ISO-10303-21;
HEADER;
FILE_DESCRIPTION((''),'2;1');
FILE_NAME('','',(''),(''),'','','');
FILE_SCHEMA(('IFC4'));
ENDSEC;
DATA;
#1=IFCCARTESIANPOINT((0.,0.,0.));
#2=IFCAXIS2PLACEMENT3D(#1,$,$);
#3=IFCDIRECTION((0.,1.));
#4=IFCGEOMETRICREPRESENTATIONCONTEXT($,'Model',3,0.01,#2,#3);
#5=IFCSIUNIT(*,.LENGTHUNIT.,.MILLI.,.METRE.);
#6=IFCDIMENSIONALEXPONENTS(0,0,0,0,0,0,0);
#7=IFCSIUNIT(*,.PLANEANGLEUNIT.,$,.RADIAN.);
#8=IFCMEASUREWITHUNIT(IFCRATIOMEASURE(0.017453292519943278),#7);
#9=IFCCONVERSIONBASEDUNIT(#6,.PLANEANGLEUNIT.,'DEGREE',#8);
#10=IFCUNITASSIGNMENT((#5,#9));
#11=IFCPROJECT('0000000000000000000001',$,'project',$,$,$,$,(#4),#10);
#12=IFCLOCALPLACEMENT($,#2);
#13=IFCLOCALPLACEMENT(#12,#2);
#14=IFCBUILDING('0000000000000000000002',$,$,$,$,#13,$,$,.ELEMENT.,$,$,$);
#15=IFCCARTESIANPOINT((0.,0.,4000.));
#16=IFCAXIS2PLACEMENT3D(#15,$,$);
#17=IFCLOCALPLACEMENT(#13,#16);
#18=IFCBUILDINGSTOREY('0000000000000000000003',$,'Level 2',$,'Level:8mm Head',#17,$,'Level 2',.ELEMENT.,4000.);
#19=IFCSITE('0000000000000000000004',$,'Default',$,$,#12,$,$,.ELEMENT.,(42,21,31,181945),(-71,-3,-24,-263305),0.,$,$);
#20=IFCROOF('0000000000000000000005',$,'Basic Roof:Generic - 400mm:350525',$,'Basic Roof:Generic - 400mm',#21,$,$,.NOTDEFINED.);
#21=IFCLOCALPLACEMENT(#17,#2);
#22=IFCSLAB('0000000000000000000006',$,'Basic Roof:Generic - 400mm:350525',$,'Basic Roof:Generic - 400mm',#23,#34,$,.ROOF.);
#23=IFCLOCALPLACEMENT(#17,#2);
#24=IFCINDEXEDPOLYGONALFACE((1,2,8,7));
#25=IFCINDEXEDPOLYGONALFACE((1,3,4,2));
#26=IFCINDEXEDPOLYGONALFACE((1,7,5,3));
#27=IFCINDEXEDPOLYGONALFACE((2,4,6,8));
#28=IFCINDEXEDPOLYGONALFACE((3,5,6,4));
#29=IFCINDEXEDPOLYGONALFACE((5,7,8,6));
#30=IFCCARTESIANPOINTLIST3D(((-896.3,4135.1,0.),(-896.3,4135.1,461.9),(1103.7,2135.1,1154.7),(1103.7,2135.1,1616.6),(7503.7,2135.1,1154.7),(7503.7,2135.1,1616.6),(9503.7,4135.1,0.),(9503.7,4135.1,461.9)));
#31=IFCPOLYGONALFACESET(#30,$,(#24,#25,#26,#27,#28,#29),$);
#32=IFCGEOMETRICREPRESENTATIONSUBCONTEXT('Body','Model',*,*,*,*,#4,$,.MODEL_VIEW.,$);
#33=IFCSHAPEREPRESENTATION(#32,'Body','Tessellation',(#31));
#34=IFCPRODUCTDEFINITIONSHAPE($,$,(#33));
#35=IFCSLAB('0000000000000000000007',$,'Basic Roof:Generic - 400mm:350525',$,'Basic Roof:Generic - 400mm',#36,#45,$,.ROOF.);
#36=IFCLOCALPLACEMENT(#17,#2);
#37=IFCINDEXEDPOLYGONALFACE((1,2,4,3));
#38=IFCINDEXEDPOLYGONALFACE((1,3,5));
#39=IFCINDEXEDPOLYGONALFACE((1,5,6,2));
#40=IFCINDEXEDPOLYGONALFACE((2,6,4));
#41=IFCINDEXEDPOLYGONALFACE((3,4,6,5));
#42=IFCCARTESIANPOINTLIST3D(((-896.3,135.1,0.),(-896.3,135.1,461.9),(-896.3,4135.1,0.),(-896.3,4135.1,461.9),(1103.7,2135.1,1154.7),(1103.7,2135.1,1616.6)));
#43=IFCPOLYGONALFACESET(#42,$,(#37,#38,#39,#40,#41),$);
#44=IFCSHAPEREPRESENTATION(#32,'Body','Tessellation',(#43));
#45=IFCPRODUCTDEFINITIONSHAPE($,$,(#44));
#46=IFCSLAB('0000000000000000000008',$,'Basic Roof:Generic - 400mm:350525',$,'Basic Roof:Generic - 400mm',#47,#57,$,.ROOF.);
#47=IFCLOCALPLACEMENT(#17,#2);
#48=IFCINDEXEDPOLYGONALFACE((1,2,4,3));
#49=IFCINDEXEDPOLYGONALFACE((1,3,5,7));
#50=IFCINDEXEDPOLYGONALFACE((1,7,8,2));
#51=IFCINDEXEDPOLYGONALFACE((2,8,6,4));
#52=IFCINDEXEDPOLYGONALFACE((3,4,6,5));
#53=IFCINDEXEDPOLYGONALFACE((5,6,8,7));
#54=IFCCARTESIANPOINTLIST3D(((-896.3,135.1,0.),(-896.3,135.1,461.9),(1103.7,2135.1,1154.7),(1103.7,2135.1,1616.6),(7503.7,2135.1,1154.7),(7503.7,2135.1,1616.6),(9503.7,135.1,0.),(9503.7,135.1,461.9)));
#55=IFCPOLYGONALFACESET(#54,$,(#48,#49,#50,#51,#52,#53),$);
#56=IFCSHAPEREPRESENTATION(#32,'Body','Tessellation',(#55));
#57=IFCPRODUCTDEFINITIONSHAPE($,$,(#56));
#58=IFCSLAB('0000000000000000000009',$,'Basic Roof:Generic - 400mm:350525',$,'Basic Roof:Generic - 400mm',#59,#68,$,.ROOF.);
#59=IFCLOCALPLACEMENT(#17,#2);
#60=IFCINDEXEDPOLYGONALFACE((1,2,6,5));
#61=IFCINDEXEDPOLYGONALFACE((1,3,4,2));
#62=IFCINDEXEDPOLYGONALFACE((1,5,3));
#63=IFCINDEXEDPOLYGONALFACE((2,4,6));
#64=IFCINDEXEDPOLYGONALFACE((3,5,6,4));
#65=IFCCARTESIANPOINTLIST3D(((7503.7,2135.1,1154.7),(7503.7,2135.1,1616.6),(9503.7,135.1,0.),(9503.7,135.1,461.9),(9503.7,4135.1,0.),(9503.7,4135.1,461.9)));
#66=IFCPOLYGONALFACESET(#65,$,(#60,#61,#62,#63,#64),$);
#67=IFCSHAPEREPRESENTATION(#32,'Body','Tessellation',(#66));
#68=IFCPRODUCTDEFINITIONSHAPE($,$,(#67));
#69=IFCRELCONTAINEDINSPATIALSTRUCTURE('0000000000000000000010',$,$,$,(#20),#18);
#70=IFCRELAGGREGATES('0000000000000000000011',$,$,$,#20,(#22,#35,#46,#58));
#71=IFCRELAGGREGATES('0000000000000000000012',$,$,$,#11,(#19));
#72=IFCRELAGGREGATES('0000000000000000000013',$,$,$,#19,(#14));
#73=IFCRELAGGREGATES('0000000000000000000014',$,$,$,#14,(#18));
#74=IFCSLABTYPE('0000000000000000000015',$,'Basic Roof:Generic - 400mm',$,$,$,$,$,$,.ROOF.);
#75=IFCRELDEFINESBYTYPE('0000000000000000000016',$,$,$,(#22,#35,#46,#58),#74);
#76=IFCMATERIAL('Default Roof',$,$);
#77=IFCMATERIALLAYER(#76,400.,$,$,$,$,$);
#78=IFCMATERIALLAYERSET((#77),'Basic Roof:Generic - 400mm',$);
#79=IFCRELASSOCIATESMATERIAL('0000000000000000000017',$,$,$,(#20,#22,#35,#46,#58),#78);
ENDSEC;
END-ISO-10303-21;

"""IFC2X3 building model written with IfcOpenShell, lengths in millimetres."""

from ifc_helpers import new_model, entity, si_unit, converted_unit, direction, frame, origin, place, context, subcontext, project, spatial, polyline, outline, extrude, material, layer, layer_set, type_object, element, aggregate, save


model = new_model("IFC2X3")

# Units and contexts
model_context = context("Model", 3, precision=0.01, world=origin(), true_north=direction((0.0, 1.0)))
body_context = subcontext(model_context, "Body", "Model", "MODEL_VIEW")
ifc_project = project(units=[si_unit("LENGTHUNIT", "METRE", prefix="MILLI"), converted_unit("PLANEANGLEUNIT", "DEGREE", entity("IfcRatioMeasure", 0.017453292519943278), si_unit("PLANEANGLEUNIT", "RADIAN"), dimensions=[0, 0, 0, 0, 0, 0, 0])], contexts=[model_context])

# Site, building, storey
site_placement = place(None, origin())
site = spatial("IfcSite", under=ifc_project, at=site_placement, Name="Default", CompositionType="ELEMENT", RefLatitude=(42, 21, 31, 181945), RefLongitude=(-71, -3, -24, -263305), RefElevation=0.0)
building_placement = place(site_placement, origin())
building = spatial("IfcBuilding", under=site, at=building_placement, CompositionType="ELEMENT")
storey_placement = place(building_placement, frame((0.0, 0.0, 4000.0)))
storey = spatial("IfcBuildingStorey", under=building, at=storey_placement, Name="Level 2", ObjectType="Level:8mm Head", LongName="Level 2", CompositionType="ELEMENT", Elevation=4000.0)

# Roof, slabs
ifc_material = material(Name="Default Roof")
ifc_layer = layer(ifc_material, 400.0)
ifc_layer_set = layer_set([ifc_layer], Name="Basic Roof:Generic - 400mm")
roof_placement = place(storey_placement, frame((-896.3, 135.1, 0.0)))
roof = element("IfcRoof", 1, at=roof_placement, inside=storey, material=ifc_layer_set, Name="Basic Roof:Generic - 400mm:350525", ObjectType="Basic Roof:Generic - 400mm", ShapeType="NOTDEFINED")
slab_type = type_object("IfcSlabType", Name="Basic Roof:Generic - 400mm", PredefinedType="ROOF")
slab_1_placement = place(roof_placement, origin())
slab_1 = element("IfcSlab", 2, at=slab_1_placement, type_object=slab_type, material=ifc_layer_set, Name="Basic Roof:Generic - 400mm:350525", ObjectType="Basic Roof:Generic - 400mm", PredefinedType="ROOF", context=body_context, shape_type="SweptSolid", body=[
    extrude(outline(polyline([(5200.0, 1154.7), (-5200.0, 1154.7), (-3200.0, -1154.7), (3200.0, -1154.7), (5200.0, 1154.7)])), frame((5200.0, 3000.0, 577.4), z_axis=(0.0, 0.5, 0.866025), x_axis=(1.0, 0.0, 0.0)), (0.0, -0.5, 0.866025), 461.9),
])
slab_2_placement = place(roof_placement, origin())
slab_2 = element("IfcSlab", 3, at=slab_2_placement, type_object=slab_type, material=ifc_layer_set, Name="Basic Roof:Generic - 400mm:350525", ObjectType="Basic Roof:Generic - 400mm", PredefinedType="ROOF", context=body_context, shape_type="SweptSolid", body=[
    extrude(outline(polyline([(-1154.7, 2000.0), (-1154.7, -2000.0), (1154.7, 0.0), (-1154.7, 2000.0)])), frame((1000.0, 2000.0, 577.4), z_axis=(-0.5, 0.0, 0.866025), x_axis=(0.866025, 0.0, 0.5)), (0.5, 0.0, 0.866025), 461.9),
])
slab_3_placement = place(roof_placement, origin())
slab_3 = element("IfcSlab", 4, at=slab_3_placement, type_object=slab_type, material=ifc_layer_set, Name="Basic Roof:Generic - 400mm:350525", ObjectType="Basic Roof:Generic - 400mm", PredefinedType="ROOF", context=body_context, shape_type="SweptSolid", body=[
    extrude(outline(polyline([(-5200.0, -1154.7), (5200.0, -1154.7), (3200.0, 1154.7), (-3200.0, 1154.7), (-5200.0, -1154.7)])), frame((5200.0, 1000.0, 577.4), z_axis=(0.0, -0.5, 0.866025), x_axis=(1.0, 0.0, 0.0)), (0.0, 0.5, 0.866025), 461.9),
])
slab_4_placement = place(roof_placement, origin())
slab_4 = element("IfcSlab", 5, at=slab_4_placement, type_object=slab_type, material=ifc_layer_set, Name="Basic Roof:Generic - 400mm:350525", ObjectType="Basic Roof:Generic - 400mm", PredefinedType="ROOF", context=body_context, shape_type="SweptSolid", body=[
    extrude(outline(polyline([(-1154.7, 0.0), (1154.7, -2000.0), (1154.7, 2000.0), (-1154.7, 0.0)])), frame((9400.0, 2000.0, 577.4), z_axis=(0.5, 0.0, 0.866025), x_axis=(0.866025, 0.0, -0.5)), (-0.5, 0.0, 0.866025), 461.9),
])
aggregate(roof, [slab_1, slab_2, slab_3, slab_4])

save(model, "model.ifc")
